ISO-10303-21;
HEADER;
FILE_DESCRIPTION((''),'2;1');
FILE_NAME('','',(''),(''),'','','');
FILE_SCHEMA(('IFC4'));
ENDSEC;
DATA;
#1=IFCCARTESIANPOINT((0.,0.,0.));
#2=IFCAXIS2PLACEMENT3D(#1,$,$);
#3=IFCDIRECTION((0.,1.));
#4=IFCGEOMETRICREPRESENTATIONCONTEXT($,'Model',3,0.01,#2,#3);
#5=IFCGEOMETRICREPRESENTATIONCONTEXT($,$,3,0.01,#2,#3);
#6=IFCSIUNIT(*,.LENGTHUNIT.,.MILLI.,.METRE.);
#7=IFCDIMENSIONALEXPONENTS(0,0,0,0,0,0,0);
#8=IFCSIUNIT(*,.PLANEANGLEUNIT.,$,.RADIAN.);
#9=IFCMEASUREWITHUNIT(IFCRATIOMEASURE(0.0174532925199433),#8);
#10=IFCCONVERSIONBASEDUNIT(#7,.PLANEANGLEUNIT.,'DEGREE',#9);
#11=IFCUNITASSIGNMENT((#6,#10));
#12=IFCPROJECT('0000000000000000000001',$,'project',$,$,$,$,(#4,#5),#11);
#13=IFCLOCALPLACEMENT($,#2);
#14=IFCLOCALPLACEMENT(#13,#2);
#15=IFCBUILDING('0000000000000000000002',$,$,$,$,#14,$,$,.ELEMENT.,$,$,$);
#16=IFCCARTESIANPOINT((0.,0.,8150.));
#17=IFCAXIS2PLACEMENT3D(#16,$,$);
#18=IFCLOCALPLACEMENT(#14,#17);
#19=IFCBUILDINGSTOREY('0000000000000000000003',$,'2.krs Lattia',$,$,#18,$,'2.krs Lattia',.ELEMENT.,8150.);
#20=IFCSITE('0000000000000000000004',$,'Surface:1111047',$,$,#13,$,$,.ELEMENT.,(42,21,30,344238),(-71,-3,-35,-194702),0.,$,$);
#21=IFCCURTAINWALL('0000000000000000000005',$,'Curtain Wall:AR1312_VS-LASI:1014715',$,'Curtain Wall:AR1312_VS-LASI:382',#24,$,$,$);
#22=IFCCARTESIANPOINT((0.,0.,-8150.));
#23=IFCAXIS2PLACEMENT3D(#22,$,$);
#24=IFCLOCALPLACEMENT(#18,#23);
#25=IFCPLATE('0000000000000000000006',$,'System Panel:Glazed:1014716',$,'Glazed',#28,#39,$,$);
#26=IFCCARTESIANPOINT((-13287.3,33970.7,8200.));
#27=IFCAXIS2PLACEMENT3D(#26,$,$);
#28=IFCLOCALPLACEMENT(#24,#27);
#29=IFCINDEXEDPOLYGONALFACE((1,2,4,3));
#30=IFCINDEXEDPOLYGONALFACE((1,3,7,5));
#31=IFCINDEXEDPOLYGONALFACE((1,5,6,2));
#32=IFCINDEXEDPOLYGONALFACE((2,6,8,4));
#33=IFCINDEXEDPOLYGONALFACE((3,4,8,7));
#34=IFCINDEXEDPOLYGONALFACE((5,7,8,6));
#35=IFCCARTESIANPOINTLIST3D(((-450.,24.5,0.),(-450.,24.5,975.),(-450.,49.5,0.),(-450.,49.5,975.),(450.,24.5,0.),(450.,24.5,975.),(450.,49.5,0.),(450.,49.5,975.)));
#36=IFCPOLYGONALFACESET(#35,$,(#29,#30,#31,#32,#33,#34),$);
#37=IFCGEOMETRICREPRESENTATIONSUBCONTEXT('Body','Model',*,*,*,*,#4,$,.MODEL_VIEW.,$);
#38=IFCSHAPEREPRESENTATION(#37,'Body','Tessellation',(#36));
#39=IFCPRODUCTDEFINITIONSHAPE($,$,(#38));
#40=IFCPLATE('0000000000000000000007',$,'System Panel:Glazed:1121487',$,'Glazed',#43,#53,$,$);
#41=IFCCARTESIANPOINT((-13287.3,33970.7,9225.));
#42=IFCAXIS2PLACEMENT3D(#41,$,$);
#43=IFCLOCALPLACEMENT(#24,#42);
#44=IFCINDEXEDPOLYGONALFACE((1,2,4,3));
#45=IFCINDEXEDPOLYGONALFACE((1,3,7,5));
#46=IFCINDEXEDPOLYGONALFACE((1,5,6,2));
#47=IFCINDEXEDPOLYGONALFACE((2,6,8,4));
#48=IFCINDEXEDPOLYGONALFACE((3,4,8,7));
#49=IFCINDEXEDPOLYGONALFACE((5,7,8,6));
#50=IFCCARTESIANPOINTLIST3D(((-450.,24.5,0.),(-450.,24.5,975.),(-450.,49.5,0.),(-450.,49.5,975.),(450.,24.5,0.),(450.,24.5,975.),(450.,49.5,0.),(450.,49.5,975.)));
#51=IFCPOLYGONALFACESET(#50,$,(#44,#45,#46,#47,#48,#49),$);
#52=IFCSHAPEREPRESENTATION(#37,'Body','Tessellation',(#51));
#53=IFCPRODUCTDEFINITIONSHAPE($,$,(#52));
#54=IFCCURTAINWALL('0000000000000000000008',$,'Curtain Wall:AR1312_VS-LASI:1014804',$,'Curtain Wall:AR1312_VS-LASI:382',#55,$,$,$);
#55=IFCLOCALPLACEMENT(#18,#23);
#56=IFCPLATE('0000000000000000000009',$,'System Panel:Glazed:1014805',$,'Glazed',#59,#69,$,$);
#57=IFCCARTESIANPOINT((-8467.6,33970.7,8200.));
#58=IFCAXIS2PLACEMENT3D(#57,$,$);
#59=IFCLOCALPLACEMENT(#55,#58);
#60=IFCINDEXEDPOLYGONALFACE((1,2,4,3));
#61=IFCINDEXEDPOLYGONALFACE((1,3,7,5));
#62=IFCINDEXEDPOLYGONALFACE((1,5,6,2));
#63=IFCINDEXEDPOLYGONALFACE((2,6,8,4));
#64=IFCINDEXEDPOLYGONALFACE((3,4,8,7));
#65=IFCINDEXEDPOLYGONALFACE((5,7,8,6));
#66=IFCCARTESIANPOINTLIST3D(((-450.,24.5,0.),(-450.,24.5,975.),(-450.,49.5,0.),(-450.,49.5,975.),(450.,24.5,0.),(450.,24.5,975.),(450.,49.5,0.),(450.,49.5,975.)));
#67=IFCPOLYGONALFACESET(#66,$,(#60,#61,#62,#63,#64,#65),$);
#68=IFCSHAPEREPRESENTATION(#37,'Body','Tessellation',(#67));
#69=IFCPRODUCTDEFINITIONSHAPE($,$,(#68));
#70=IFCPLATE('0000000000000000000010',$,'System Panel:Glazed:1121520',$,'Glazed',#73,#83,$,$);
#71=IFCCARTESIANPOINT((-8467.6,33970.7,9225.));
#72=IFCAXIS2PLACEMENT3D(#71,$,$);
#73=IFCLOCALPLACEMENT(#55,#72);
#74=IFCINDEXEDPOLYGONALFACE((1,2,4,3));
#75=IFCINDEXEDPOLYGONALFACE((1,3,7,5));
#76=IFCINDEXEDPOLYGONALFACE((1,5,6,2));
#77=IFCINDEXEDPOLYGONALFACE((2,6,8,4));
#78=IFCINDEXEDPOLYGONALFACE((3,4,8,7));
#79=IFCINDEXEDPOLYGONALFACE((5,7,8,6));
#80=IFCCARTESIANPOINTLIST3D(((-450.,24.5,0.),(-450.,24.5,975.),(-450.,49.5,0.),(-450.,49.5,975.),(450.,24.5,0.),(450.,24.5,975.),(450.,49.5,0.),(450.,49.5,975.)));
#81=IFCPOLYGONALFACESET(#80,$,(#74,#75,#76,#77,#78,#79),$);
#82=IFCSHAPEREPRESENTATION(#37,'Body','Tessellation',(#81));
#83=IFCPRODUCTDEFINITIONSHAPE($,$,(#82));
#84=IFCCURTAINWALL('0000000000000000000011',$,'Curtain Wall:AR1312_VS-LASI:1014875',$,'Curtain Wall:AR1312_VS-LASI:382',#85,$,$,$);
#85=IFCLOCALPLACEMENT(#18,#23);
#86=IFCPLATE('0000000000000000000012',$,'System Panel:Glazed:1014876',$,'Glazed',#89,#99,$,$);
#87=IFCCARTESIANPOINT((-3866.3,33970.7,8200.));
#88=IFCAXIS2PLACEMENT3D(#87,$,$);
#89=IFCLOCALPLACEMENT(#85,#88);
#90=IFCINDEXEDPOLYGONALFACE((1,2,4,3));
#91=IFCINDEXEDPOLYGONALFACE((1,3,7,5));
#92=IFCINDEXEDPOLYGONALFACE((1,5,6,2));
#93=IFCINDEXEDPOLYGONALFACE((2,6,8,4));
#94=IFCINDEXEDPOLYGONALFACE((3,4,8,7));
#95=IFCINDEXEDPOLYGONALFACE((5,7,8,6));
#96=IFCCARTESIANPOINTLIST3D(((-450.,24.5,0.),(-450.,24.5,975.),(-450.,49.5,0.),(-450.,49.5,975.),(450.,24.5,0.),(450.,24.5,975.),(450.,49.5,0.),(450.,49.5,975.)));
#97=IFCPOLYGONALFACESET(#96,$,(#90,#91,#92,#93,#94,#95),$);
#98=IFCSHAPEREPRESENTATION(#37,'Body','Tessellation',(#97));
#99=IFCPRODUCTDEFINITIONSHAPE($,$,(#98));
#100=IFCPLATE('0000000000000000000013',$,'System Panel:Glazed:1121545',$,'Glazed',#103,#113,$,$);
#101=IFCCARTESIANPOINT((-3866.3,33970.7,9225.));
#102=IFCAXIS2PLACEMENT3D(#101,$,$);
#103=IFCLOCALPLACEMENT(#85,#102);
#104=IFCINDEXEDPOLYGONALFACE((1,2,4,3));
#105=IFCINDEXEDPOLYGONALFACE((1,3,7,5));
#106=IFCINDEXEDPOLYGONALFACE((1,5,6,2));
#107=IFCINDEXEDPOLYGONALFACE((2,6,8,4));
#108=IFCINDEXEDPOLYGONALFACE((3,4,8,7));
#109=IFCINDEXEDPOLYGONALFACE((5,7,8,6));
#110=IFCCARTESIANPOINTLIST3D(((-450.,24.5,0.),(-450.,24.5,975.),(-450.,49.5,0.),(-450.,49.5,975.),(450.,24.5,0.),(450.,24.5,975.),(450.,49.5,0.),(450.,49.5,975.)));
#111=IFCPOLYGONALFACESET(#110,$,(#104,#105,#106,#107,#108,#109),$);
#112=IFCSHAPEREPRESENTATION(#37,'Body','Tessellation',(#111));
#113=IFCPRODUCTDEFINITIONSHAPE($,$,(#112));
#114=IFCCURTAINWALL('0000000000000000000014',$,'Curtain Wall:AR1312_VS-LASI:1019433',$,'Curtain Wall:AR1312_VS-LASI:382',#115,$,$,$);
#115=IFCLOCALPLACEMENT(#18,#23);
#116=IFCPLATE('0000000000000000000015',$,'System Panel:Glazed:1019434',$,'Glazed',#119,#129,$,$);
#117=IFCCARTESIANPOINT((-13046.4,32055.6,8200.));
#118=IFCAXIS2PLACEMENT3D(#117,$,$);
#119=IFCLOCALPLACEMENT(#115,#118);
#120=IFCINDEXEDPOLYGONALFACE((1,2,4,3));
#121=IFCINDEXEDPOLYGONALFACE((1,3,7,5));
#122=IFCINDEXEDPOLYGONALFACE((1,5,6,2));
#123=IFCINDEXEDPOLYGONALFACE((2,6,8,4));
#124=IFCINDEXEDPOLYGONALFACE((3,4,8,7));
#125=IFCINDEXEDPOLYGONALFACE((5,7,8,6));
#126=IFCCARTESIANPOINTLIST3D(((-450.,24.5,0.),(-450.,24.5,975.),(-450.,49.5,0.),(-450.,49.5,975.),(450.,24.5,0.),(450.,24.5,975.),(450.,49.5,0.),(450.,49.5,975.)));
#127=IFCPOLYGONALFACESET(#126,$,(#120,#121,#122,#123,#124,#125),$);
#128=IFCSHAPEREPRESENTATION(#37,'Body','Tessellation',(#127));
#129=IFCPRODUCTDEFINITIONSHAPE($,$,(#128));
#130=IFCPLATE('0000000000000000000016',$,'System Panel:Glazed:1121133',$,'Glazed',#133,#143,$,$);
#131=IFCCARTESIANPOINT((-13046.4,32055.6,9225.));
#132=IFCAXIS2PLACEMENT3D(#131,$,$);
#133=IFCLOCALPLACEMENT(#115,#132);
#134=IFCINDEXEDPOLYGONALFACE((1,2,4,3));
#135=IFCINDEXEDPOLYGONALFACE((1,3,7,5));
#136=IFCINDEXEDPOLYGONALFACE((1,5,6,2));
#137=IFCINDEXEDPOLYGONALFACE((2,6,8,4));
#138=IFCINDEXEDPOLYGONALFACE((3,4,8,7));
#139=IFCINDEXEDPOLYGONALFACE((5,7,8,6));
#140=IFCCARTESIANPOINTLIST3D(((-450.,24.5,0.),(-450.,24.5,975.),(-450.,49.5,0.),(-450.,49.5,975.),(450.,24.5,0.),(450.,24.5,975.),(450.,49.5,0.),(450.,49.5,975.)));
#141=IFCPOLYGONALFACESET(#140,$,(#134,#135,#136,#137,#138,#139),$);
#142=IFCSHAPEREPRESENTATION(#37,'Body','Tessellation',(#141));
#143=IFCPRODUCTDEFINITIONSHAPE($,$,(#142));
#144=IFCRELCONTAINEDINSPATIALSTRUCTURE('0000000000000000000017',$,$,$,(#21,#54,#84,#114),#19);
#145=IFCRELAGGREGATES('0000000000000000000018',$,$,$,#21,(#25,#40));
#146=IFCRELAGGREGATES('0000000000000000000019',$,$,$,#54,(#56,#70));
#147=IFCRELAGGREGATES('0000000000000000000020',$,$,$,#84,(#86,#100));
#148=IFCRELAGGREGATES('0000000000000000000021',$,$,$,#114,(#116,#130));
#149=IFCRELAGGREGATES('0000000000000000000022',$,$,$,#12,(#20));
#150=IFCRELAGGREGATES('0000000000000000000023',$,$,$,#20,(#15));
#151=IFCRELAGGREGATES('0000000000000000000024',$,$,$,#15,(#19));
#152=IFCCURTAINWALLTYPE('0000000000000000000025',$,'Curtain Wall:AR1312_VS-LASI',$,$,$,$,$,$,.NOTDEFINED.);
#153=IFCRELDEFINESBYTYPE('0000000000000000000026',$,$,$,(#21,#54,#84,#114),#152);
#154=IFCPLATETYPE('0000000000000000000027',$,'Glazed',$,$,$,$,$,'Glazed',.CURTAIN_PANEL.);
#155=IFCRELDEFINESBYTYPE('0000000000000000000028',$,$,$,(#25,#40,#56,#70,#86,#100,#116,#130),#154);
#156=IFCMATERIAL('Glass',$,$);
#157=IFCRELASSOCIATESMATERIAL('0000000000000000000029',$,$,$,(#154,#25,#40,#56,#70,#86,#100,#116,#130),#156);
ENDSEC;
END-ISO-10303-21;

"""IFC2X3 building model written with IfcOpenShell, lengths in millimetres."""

from ifc_helpers import new_model, entity, si_unit, converted_unit, direction, frame, origin, origin_2d_with_axis, place, context, subcontext, project, spatial, rectangle, extrude, source, transform, mapped, material, type_object, type_shapes, element, aggregate, save


model = new_model("IFC2X3")

# Units and contexts
model_context = context("Model", 3, precision=0.01, world=origin(), true_north=direction((0.0, 1.0)))
context_of_model = context(None, 3, precision=0.01, world=origin(), true_north=direction((0.0, 1.0)))
body_context = subcontext(model_context, "Body", "Model", "MODEL_VIEW")
ifc_project = project(units=[si_unit("LENGTHUNIT", "METRE", prefix="MILLI"), converted_unit("PLANEANGLEUNIT", "DEGREE", entity("IfcRatioMeasure", 0.0174532925199433), si_unit("PLANEANGLEUNIT", "RADIAN"), dimensions=[0, 0, 0, 0, 0, 0, 0])], contexts=[model_context, context_of_model])

# Site, building, storey
site_placement = place(None, origin())
site = spatial("IfcSite", under=ifc_project, at=site_placement, Name="Surface:1111047", CompositionType="ELEMENT", RefLatitude=(42, 21, 30, 344238), RefLongitude=(-71, -3, -35, -194702), RefElevation=0.0)
building_placement = place(site_placement, origin())
building = spatial("IfcBuilding", under=site, at=building_placement, CompositionType="ELEMENT")
storey_placement = place(building_placement, frame((0.0, 0.0, 8150.0)))
storey = spatial("IfcBuildingStorey", under=building, at=storey_placement, Name="2.krs Lattia", LongName="2.krs Lattia", CompositionType="ELEMENT", Elevation=8150.0)

# Curtain walls, plates
curtain_wall_type = type_object("IfcCurtainWallType", Name="Curtain Wall:AR1312_VS-LASI", PredefinedType="NOTDEFINED")
curtain_wall_1_placement = place(storey_placement, frame((0.0, 0.0, -8150.0)))
curtain_wall_1 = element("IfcCurtainWall", 1, at=curtain_wall_1_placement, inside=storey, type_object=curtain_wall_type, Name="Curtain Wall:AR1312_VS-LASI:1014715", ObjectType="Curtain Wall:AR1312_VS-LASI:382")
ifc_material_1 = material(Name="Glass")
plate_type = type_object("IfcPlateType", Name="Glazed", ElementType="Glazed", PredefinedType="CURTAIN_PANEL", material=ifc_material_1)
shared_shape_1 = source(origin(), body_context, "Body", "SweptSolid", [
    extrude(rectangle(XDim=25.0, YDim=900.0, at=origin_2d_with_axis()), frame((0.0, 37.0, 0.0), z_axis=(0.0, 0.0, 1.0), x_axis=(0.0, 1.0, 0.0)), (0.0, 0.0, 1.0), 975.0),
])
type_shapes(plate_type, [shared_shape_1])
plate_1_placement = place(curtain_wall_1_placement, frame((-13287.3, 33970.7, 8200.0)))
plate_1 = element("IfcPlate", 2, at=plate_1_placement, type_object=plate_type, material=ifc_material_1, Name="System Panel:Glazed:1014716", ObjectType="Glazed", context=body_context, shape_type="MappedRepresentation", body=[
    mapped(shared_shape_1, transform((0.0, 0.0, 0.0), scale=1.0)),
])
plate_2_placement = place(curtain_wall_1_placement, frame((-13287.3, 33970.7, 9225.0)))
plate_2 = element("IfcPlate", 3, at=plate_2_placement, type_object=plate_type, material=ifc_material_1, Name="System Panel:Glazed:1121487", ObjectType="Glazed", context=body_context, shape_type="MappedRepresentation", body=[
    mapped(shared_shape_1, transform((0.0, 0.0, 0.0), scale=1.0)),
])
aggregate(curtain_wall_1, [plate_1, plate_2])
curtain_wall_2_placement = place(storey_placement, frame((0.0, 0.0, -8150.0)))
curtain_wall_2 = element("IfcCurtainWall", 4, at=curtain_wall_2_placement, inside=storey, type_object=curtain_wall_type, Name="Curtain Wall:AR1312_VS-LASI:1014804", ObjectType="Curtain Wall:AR1312_VS-LASI:382")
plate_3_placement = place(curtain_wall_2_placement, frame((-8467.6, 33970.7, 8200.0)))
plate_3 = element("IfcPlate", 5, at=plate_3_placement, type_object=plate_type, material=ifc_material_1, Name="System Panel:Glazed:1014805", ObjectType="Glazed", context=body_context, shape_type="MappedRepresentation", body=[
    mapped(shared_shape_1, transform((0.0, 0.0, 0.0), scale=1.0)),
])
plate_4_placement = place(curtain_wall_2_placement, frame((-8467.6, 33970.7, 9225.0)))
plate_4 = element("IfcPlate", 6, at=plate_4_placement, type_object=plate_type, material=ifc_material_1, Name="System Panel:Glazed:1121520", ObjectType="Glazed", context=body_context, shape_type="MappedRepresentation", body=[
    mapped(shared_shape_1, transform((0.0, 0.0, 0.0), scale=1.0)),
])
aggregate(curtain_wall_2, [plate_3, plate_4])
curtain_wall_3_placement = place(storey_placement, frame((0.0, 0.0, -8150.0)))
curtain_wall_3 = element("IfcCurtainWall", 7, at=curtain_wall_3_placement, inside=storey, type_object=curtain_wall_type, Name="Curtain Wall:AR1312_VS-LASI:1014875", ObjectType="Curtain Wall:AR1312_VS-LASI:382")
plate_5_placement = place(curtain_wall_3_placement, frame((-3866.3, 33970.7, 8200.0)))
plate_5 = element("IfcPlate", 8, at=plate_5_placement, type_object=plate_type, material=ifc_material_1, Name="System Panel:Glazed:1014876", ObjectType="Glazed", context=body_context, shape_type="MappedRepresentation", body=[
    mapped(shared_shape_1, transform((0.0, 0.0, 0.0), scale=1.0)),
])
plate_6_placement = place(curtain_wall_3_placement, frame((-3866.3, 33970.7, 9225.0)))
plate_6 = element("IfcPlate", 9, at=plate_6_placement, type_object=plate_type, material=ifc_material_1, Name="System Panel:Glazed:1121545", ObjectType="Glazed", context=body_context, shape_type="MappedRepresentation", body=[
    mapped(shared_shape_1, transform((0.0, 0.0, 0.0), scale=1.0)),
])
aggregate(curtain_wall_3, [plate_5, plate_6])
curtain_wall_4_placement = place(storey_placement, frame((0.0, 0.0, -8150.0)))
curtain_wall_4 = element("IfcCurtainWall", 10, at=curtain_wall_4_placement, inside=storey, type_object=curtain_wall_type, Name="Curtain Wall:AR1312_VS-LASI:1019433", ObjectType="Curtain Wall:AR1312_VS-LASI:382")
plate_7_placement = place(curtain_wall_4_placement, frame((-13046.4, 32055.6, 8200.0)))
plate_7 = element("IfcPlate", 11, at=plate_7_placement, type_object=plate_type, material=ifc_material_1, Name="System Panel:Glazed:1019434", ObjectType="Glazed", context=body_context, shape_type="MappedRepresentation", body=[
    mapped(shared_shape_1, transform((0.0, 0.0, 0.0), scale=1.0)),
])
plate_8_placement = place(curtain_wall_4_placement, frame((-13046.4, 32055.6, 9225.0)))
plate_8 = element("IfcPlate", 12, at=plate_8_placement, type_object=plate_type, material=ifc_material_1, Name="System Panel:Glazed:1121133", ObjectType="Glazed", context=body_context, shape_type="MappedRepresentation", body=[
    mapped(shared_shape_1, transform((0.0, 0.0, 0.0), scale=1.0)),
])
aggregate(curtain_wall_4, [plate_7, plate_8])

save(model, "model.ifc")
